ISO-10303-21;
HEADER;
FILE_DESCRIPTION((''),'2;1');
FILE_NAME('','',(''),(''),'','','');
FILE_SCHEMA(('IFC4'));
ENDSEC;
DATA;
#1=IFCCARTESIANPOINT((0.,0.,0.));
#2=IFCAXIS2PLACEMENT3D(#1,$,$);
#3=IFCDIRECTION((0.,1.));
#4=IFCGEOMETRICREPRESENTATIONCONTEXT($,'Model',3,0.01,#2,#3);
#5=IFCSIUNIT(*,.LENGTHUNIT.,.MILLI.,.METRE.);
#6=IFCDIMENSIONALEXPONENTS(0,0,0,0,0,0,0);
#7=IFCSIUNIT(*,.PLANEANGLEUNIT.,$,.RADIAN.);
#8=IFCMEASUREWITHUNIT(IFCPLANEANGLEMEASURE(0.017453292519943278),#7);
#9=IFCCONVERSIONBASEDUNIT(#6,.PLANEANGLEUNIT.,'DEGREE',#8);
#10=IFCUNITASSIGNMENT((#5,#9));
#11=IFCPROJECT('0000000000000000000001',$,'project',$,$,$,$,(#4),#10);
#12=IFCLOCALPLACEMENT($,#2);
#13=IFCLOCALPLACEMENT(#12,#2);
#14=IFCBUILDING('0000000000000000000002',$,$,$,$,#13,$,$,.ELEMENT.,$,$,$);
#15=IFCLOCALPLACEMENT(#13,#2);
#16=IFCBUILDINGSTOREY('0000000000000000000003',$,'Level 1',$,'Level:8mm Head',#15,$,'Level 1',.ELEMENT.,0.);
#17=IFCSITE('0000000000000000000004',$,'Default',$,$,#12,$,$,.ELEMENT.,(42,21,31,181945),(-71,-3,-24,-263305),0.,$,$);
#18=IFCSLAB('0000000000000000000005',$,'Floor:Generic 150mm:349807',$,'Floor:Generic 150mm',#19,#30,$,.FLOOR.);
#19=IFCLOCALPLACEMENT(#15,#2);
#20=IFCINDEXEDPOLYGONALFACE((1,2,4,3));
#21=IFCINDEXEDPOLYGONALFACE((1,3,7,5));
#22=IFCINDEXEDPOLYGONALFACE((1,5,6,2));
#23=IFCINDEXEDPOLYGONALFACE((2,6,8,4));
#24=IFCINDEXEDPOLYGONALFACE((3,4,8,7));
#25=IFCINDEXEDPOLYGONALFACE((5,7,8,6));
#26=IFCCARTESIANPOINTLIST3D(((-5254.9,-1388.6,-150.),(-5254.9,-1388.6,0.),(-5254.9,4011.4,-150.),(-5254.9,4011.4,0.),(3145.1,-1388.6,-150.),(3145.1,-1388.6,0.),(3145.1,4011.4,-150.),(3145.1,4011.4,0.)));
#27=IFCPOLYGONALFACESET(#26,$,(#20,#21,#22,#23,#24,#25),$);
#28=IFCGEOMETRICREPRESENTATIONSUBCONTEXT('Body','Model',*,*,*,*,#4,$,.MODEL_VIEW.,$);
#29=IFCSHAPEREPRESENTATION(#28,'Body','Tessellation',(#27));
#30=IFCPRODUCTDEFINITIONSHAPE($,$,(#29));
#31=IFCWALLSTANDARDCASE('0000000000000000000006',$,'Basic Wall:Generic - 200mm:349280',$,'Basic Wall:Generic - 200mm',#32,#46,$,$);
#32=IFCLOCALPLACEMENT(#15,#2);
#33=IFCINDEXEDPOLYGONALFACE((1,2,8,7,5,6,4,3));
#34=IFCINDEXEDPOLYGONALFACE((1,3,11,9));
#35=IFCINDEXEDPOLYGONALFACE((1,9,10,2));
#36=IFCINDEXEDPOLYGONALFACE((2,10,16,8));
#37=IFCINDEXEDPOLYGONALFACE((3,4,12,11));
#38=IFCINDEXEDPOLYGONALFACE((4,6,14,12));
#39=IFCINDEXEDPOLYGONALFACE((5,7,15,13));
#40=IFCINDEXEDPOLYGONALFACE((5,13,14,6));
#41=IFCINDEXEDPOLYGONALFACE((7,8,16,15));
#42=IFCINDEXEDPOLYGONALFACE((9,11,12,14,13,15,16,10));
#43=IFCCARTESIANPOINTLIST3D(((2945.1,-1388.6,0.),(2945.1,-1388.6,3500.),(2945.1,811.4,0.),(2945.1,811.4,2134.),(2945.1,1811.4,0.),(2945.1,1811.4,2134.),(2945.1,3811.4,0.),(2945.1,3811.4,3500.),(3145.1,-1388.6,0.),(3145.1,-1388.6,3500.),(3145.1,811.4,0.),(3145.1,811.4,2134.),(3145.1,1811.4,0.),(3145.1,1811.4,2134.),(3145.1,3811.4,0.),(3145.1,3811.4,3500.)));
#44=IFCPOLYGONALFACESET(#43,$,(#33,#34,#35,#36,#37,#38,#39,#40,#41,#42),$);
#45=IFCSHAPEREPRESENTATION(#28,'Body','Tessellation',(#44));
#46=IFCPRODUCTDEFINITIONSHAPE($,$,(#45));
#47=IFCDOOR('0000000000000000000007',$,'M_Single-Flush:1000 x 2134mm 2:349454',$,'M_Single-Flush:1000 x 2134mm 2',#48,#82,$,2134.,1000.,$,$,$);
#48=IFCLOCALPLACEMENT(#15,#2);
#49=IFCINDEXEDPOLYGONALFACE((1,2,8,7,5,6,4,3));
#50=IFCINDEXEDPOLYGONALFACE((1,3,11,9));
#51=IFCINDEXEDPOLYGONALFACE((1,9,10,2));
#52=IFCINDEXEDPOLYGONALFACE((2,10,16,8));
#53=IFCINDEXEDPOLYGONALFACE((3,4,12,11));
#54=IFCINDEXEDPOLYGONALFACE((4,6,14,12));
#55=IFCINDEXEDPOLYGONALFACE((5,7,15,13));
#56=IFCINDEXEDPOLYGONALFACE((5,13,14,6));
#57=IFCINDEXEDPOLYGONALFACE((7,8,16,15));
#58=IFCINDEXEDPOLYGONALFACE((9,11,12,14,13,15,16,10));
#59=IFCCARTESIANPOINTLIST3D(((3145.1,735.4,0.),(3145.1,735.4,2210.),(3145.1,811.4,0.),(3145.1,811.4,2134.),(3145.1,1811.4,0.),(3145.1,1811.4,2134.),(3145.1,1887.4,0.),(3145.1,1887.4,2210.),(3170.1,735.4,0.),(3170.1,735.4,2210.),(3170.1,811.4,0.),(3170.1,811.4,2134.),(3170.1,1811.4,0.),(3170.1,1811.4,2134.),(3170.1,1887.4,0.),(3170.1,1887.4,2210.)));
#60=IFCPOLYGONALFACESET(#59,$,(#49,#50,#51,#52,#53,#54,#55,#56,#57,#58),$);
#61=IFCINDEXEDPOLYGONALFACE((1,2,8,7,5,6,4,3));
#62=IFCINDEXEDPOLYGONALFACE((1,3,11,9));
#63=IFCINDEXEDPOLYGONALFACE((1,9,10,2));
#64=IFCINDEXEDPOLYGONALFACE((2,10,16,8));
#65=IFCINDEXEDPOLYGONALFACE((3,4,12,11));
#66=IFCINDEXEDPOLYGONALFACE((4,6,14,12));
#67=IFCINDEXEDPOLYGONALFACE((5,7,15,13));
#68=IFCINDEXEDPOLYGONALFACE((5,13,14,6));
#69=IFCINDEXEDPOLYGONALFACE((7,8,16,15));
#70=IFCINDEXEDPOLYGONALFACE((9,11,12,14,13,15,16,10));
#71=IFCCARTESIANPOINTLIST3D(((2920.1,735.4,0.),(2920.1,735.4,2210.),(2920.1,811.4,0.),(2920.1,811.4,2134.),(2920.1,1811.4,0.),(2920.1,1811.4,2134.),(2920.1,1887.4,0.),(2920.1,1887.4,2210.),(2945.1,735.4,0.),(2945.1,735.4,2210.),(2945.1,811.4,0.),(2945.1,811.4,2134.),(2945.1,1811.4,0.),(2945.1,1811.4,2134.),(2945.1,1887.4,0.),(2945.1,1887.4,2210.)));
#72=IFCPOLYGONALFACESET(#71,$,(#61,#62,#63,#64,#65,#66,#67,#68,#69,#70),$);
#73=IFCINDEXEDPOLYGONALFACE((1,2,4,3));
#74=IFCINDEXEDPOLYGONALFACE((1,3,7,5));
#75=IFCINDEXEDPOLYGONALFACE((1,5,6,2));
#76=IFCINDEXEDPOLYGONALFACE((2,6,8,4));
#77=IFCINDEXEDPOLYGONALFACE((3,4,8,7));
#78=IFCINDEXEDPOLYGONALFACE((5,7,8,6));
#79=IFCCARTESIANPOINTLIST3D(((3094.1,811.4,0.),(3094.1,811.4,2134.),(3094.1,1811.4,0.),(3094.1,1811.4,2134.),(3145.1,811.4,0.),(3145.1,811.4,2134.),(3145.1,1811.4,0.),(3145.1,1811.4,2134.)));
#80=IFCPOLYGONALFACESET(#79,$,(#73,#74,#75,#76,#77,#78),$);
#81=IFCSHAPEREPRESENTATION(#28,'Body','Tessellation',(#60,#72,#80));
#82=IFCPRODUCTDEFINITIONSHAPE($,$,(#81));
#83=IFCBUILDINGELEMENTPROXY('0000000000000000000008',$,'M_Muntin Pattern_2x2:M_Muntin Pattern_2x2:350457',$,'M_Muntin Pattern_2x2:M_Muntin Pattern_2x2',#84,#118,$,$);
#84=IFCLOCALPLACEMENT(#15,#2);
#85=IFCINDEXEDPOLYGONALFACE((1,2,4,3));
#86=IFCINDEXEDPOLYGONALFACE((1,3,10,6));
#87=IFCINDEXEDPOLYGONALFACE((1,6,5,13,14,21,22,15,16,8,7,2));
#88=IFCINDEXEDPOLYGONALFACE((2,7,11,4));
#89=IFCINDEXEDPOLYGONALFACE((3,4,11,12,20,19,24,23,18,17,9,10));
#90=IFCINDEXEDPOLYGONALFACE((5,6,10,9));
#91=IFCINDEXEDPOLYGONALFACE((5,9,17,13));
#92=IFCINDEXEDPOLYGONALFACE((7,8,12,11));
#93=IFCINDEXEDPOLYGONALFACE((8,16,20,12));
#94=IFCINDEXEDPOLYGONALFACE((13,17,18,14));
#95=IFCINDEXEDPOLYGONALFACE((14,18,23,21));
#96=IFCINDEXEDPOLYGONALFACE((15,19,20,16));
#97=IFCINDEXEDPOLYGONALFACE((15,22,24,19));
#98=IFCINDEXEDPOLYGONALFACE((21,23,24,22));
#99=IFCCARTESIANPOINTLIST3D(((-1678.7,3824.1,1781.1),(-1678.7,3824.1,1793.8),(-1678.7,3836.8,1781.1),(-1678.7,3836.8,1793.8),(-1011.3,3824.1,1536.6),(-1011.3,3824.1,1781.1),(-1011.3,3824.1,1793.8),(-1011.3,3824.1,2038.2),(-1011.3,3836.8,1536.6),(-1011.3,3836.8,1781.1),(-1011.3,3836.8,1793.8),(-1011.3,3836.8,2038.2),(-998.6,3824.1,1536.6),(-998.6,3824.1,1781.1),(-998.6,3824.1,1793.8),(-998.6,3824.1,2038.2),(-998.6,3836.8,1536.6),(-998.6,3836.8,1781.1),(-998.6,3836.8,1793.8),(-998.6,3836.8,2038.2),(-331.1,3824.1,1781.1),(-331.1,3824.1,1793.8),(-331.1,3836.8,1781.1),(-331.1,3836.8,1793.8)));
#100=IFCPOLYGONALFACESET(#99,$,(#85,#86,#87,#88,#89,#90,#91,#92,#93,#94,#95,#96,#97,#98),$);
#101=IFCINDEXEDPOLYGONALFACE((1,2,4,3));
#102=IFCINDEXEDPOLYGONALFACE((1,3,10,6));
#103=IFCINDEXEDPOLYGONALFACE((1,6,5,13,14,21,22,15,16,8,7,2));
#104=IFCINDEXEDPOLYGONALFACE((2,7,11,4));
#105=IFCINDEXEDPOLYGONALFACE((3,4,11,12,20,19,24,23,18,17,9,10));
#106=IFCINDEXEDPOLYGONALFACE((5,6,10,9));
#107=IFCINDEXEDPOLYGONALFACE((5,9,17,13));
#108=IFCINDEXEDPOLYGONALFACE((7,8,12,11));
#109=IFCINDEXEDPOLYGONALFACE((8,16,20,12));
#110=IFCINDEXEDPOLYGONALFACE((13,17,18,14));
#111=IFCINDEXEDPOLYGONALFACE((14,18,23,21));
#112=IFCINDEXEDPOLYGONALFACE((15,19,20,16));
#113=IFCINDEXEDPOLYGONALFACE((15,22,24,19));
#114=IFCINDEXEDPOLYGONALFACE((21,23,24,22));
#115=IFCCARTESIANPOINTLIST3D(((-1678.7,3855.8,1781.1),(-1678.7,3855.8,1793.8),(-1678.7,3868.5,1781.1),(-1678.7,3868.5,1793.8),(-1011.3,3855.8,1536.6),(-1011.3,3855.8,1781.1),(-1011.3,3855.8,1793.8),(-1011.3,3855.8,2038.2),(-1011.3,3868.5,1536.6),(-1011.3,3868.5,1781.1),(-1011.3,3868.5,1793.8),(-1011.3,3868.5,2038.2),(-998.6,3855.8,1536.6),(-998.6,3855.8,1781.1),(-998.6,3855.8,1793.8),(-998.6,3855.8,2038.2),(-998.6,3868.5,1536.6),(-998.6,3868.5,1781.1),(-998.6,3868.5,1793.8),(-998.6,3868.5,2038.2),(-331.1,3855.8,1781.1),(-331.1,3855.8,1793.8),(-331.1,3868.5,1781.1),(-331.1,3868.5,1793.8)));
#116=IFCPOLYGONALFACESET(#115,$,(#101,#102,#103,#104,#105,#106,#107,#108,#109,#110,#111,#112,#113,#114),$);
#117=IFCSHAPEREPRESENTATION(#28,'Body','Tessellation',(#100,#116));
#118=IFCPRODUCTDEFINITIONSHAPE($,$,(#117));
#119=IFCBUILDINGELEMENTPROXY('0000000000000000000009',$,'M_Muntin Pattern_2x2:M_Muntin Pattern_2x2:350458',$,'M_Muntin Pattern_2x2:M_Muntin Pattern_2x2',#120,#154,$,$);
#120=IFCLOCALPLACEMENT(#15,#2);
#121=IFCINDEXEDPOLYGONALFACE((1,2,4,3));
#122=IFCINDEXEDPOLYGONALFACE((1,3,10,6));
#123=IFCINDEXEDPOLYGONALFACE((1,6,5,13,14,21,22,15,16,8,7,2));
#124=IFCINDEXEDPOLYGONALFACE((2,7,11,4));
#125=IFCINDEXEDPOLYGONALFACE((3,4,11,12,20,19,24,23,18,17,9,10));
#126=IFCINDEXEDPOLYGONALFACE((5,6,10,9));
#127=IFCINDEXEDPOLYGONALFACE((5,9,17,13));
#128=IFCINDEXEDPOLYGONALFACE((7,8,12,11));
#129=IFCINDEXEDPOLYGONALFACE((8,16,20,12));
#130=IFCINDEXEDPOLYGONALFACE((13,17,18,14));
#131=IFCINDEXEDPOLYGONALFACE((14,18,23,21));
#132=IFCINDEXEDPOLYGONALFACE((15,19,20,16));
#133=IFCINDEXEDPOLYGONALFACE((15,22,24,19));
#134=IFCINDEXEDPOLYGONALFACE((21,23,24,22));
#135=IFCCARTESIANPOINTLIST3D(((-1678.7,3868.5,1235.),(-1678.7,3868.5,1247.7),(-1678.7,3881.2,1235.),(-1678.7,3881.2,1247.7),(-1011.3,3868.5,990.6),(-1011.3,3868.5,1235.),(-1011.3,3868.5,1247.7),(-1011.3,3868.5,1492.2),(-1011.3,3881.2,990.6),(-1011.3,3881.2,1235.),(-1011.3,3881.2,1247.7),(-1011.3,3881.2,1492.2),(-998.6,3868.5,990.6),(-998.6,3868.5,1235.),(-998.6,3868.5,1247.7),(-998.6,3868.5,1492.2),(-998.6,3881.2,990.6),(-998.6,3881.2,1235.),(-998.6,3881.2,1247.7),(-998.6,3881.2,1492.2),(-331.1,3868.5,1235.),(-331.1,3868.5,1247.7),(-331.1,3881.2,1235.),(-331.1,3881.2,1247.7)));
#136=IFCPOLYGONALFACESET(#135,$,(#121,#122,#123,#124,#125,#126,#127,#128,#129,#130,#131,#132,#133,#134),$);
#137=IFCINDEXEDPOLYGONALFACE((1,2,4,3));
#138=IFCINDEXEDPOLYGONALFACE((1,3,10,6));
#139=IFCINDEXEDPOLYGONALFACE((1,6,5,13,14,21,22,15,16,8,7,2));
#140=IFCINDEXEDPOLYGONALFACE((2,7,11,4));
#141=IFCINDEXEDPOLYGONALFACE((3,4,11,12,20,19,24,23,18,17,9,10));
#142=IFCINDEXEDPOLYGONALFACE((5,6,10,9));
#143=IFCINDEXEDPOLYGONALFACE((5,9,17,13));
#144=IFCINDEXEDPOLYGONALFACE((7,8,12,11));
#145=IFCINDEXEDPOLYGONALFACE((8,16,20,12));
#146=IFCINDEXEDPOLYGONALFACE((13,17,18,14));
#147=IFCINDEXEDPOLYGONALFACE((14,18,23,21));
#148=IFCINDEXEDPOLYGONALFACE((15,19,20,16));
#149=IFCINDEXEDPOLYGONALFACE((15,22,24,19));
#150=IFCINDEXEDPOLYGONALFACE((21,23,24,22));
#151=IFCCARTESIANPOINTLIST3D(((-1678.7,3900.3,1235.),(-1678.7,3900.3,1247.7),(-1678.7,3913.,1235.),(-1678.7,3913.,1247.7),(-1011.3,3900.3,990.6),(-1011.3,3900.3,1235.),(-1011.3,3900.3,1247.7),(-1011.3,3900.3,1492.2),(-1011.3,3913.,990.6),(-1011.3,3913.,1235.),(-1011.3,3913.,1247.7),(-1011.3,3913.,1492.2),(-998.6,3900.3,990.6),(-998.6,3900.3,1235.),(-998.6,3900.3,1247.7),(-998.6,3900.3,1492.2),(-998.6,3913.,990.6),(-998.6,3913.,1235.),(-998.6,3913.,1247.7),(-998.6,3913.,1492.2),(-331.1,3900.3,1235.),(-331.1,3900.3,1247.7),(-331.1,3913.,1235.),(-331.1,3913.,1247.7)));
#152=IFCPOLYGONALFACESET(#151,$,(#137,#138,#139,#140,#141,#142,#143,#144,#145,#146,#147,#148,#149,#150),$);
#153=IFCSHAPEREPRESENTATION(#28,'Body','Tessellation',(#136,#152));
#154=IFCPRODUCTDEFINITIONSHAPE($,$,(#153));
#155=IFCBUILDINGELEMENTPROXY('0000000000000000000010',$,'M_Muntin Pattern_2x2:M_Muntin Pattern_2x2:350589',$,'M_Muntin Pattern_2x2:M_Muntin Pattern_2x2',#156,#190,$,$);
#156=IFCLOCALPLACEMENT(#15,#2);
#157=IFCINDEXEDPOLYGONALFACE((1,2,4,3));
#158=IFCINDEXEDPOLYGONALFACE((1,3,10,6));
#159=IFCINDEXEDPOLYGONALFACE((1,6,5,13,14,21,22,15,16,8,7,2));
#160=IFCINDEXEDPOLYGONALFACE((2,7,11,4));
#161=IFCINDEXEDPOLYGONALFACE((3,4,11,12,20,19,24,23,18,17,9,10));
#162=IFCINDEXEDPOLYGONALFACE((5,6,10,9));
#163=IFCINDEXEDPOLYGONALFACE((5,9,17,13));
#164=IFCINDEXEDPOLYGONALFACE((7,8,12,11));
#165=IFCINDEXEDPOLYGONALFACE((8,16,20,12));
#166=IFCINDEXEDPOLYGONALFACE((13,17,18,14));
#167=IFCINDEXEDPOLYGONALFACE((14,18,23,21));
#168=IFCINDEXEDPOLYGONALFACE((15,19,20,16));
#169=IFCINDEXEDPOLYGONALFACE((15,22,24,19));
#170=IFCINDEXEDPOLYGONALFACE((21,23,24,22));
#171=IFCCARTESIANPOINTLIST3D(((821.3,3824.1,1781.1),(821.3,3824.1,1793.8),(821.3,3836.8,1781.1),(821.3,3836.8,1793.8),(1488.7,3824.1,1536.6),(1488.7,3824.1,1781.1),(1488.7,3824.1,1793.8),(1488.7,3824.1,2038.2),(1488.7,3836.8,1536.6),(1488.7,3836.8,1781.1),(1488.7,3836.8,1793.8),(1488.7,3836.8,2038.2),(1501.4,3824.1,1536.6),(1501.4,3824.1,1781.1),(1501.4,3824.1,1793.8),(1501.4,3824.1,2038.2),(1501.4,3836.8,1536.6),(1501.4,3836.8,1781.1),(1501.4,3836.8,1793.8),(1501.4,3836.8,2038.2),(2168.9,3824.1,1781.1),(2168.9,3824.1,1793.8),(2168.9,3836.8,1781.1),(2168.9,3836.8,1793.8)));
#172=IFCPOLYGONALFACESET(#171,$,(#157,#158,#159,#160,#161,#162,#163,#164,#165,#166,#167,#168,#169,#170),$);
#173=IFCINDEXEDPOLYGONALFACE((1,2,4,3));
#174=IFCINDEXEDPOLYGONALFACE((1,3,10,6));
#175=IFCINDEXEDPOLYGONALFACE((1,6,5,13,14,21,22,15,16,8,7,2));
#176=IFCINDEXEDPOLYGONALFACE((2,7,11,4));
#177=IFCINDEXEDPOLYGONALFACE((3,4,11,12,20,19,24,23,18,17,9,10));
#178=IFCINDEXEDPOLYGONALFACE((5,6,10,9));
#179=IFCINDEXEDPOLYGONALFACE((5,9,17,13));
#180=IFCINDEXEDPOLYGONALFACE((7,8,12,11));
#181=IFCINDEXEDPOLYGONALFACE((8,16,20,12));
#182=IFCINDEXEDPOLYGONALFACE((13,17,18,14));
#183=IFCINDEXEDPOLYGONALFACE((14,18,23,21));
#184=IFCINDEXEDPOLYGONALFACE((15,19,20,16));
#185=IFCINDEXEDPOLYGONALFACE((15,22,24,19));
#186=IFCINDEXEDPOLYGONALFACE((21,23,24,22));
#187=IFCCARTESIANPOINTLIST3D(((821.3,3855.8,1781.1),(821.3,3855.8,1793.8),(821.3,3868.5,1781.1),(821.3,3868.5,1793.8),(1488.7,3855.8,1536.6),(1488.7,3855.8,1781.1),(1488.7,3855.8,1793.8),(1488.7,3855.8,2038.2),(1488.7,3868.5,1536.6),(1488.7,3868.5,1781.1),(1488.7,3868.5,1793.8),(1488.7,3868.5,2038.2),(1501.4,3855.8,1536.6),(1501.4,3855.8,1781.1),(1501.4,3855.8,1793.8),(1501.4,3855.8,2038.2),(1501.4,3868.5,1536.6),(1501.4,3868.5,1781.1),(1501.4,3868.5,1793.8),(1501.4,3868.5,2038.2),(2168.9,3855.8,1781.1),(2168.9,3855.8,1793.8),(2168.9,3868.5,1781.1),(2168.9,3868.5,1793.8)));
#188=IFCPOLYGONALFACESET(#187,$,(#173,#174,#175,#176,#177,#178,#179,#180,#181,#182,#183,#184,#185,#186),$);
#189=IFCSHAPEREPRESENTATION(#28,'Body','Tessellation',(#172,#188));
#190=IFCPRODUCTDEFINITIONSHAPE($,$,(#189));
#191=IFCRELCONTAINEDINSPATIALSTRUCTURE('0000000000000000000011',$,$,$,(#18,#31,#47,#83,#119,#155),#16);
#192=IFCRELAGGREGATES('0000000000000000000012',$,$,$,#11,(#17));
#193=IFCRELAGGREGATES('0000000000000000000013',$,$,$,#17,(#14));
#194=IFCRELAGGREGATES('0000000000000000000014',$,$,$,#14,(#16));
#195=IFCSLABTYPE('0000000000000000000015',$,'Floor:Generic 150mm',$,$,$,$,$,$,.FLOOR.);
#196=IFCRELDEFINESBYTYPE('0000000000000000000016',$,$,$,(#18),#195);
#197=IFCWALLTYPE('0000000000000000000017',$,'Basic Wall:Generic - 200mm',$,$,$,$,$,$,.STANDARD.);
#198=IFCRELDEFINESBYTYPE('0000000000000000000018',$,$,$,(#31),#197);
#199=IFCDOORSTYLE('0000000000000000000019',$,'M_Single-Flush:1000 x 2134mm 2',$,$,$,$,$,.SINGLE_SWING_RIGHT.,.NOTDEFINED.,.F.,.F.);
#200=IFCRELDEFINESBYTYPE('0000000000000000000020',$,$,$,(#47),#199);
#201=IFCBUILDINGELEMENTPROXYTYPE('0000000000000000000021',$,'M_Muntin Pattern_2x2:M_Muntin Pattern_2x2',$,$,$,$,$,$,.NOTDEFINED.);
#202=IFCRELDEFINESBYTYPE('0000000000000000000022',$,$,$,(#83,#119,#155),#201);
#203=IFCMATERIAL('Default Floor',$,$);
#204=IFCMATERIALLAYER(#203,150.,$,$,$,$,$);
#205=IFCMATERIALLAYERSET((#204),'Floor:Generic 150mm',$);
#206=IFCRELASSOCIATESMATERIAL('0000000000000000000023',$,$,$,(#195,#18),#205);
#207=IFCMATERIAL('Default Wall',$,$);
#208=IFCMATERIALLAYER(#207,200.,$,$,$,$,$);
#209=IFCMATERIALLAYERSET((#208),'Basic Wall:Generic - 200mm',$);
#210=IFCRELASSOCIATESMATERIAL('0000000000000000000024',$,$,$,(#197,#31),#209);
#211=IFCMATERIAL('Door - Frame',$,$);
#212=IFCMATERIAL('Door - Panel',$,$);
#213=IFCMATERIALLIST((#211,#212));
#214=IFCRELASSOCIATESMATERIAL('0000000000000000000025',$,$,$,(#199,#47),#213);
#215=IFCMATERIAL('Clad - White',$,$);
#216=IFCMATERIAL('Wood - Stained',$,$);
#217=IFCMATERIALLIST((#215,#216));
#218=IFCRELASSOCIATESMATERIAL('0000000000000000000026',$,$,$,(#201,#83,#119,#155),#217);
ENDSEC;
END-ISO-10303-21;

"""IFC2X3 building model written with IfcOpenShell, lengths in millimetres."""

from ifc_helpers import new_model, entity, si_unit, converted_unit, direction, frame, frame_2d, origin, place, context, subcontext, project, spatial, polyline, rectangle, outline, extrude, source, transform, mapped, material, material_list, layer, layer_set, layer_usage, type_object, type_shapes, element, fill, save


model = new_model("IFC2X3")

# Units and contexts
model_context = context("Model", 3, precision=0.01, world=origin(), true_north=direction((0.0, 1.0)))
body_context = subcontext(model_context, "Body", "Model", "MODEL_VIEW")
ifc_project = project(units=[si_unit("LENGTHUNIT", "METRE", prefix="MILLI"), converted_unit("PLANEANGLEUNIT", "DEGREE", entity("IfcPlaneAngleMeasure", 0.017453292519943278), si_unit("PLANEANGLEUNIT", "RADIAN"), dimensions=[0, 0, 0, 0, 0, 0, 0])], contexts=[model_context])

# Site, building, storey
site_placement = place(None, origin())
site = spatial("IfcSite", under=ifc_project, at=site_placement, Name="Default", CompositionType="ELEMENT", RefLatitude=(42, 21, 31, 181945), RefLongitude=(-71, -3, -24, -263305), RefElevation=0.0)
building_placement = place(site_placement, origin())
building = spatial("IfcBuilding", under=site, at=building_placement, CompositionType="ELEMENT")
storey_placement = place(building_placement, origin())
storey = spatial("IfcBuildingStorey", under=building, at=storey_placement, Name="Level 1", ObjectType="Level:8mm Head", LongName="Level 1", CompositionType="ELEMENT", Elevation=0.0)

# Slab
ifc_material_1 = material(Name="Default Floor")
ifc_layer_1 = layer(ifc_material_1, 150.0)
ifc_layer_set_1 = layer_set([ifc_layer_1], Name="Floor:Generic 150mm")
ifc_layer_usage_1 = layer_usage(ifc_layer_set_1, "AXIS3", "POSITIVE", 0.0)
slab_type = type_object("IfcSlabType", Name="Floor:Generic 150mm", PredefinedType="FLOOR", material=ifc_layer_set_1)
slab_placement = place(storey_placement, origin())
element("IfcSlab", 1, at=slab_placement, inside=storey, type_object=slab_type, material=ifc_layer_usage_1, Name="Floor:Generic 150mm:349807", ObjectType="Floor:Generic 150mm", PredefinedType="FLOOR", context=body_context, shape_type="SweptSolid", body=[
    extrude(rectangle(XDim=5400.0, YDim=8400.0, at=frame_2d((0.0, 0.0), x_axis=(1.0, 0.0))), frame((-1054.9, 1311.4, 0.0), z_axis=(0.0, 0.0, -1.0), x_axis=(0.0, 1.0, 0.0)), (0.0, 0.0, 1.0), 150.0),
])

# Wall, opening, door
ifc_material_2 = material(Name="Default Wall")
ifc_layer_2 = layer(ifc_material_2, 200.0)
ifc_layer_set_2 = layer_set([ifc_layer_2], Name="Basic Wall:Generic - 200mm")
ifc_layer_usage_2 = layer_usage(ifc_layer_set_2, "AXIS2", "NEGATIVE", 100.0)
wall_type = type_object("IfcWallType", Name="Basic Wall:Generic - 200mm", PredefinedType="STANDARD", material=ifc_layer_set_2)
wall_1_placement = place(storey_placement, frame((3045.1, 3811.4, 0.0), z_axis=(0.0, 0.0, 1.0), x_axis=(0.0, -1.0, 0.0)))
wall_1 = element("IfcWallStandardCase", 2, at=wall_1_placement, inside=storey, type_object=wall_type, material=ifc_layer_usage_2, Name="Basic Wall:Generic - 200mm:349280", ObjectType="Basic Wall:Generic - 200mm", context=body_context, shape_type="SweptSolid", body=[
    extrude(rectangle(XDim=5200.0, YDim=200.0, at=frame_2d((2600.0, 0.0), x_axis=(-1.0, 0.0))), origin(), (0.0, 0.0, 1.0), 3500.0),
])
opening_1_placement = place(wall_1_placement, frame((2000.0, -100.0, 0.0)))
opening_1 = element("IfcOpeningElement", 3, at=opening_1_placement, cuts=wall_1, ObjectType="Opening", context=body_context, shape_type="SweptSolid", body=[
    extrude(rectangle(XDim=1000.0, YDim=2134.0, at=frame_2d((1067.0, 500.0), x_axis=(0.0, 1.0))), frame((0.0, 0.0, 0.0), z_axis=(0.0, 1.0, 0.0), x_axis=(0.0, 0.0, 1.0)), (0.0, 0.0, 1.0), 200.0),
])
ifc_material_3 = material(Name="Door - Frame")
ifc_material_4 = material(Name="Door - Panel")
ifc_material_list_1 = material_list([ifc_material_3, ifc_material_4])
door_style = type_object("IfcDoorStyle", Name="M_Single-Flush:1000 x 2134mm 2", ConstructionType="NOTDEFINED", OperationType="SINGLE_SWING_RIGHT", ParameterTakesPrecedence=False, Sizeable=False, material=ifc_material_list_1)
shared_shape_1 = source(origin(), body_context, "Body", "SweptSolid", [
    extrude(outline(polyline([(-576.0, -1124.0), (576.0, -1124.0), (576.0, 1086.0), (500.0, 1086.0), (500.0, -1048.0), (-500.0, -1048.0), (-500.0, 1086.0), (-576.0, 1086.0), (-576.0, -1124.0)])), frame((500.0, 200.0, 1086.0), z_axis=(0.0, 1.0, 0.0), x_axis=(1.0, 0.0, 0.0)), (0.0, 0.0, 1.0), 25.0),
    extrude(outline(polyline([(-1124.0, -576.0), (1086.0, -576.0), (1086.0, -500.0), (-1048.0, -500.0), (-1048.0, 500.0), (1086.0, 500.0), (1086.0, 576.0), (-1124.0, 576.0), (-1124.0, -576.0)])), frame((500.0, -25.0, 1086.0), z_axis=(0.0, 1.0, 0.0), x_axis=(0.0, 0.0, -1.0)), (0.0, 0.0, 1.0), 25.0),
    extrude(rectangle(XDim=51.0, YDim=1000.0, at=frame_2d((0.0, 0.0), x_axis=(1.0, 0.0))), frame((500.0, 174.5, 0.0), z_axis=(0.0, 0.0, 1.0), x_axis=(0.0, 1.0, 0.0)), (0.0, 0.0, 1.0), 2134.0),
])
type_shapes(door_style, [shared_shape_1])
door_placement = place(opening_1_placement, origin())
door = element("IfcDoor", 4, at=door_placement, inside=storey, type_object=door_style, material=ifc_material_list_1, Name="M_Single-Flush:1000 x 2134mm 2:349454", ObjectType="M_Single-Flush:1000 x 2134mm 2", OverallHeight=2134.0, OverallWidth=1000.0, context=body_context, shape_type="MappedRepresentation", body=[
    mapped(shared_shape_1, transform((0.0, 0.0, 0.0), scale=1.0)),
])
fill(opening_1, door)

# Shared definitions
ifc_material_5 = material(Name="Wood - Stained")

# Building element proxies
ifc_material_6 = material(Name="Clad - White")
ifc_material_list_2 = material_list([ifc_material_6, ifc_material_5])
building_element_proxy_type_1 = type_object("IfcBuildingElementProxyType", Name="M_Muntin Pattern_2x2:M_Muntin Pattern_2x2", PredefinedType="NOTDEFINED", material=ifc_material_list_2)
shared_shape_2 = source(origin(), body_context, "Body", "SweptSolid", [
    extrude(outline(polyline([(6.4, -6.4), (250.8, -6.4), (250.8, 6.3), (6.4, 6.3), (6.4, 673.8), (-6.3, 673.8), (-6.3, 6.3), (-250.8, 6.3), (-250.8, -6.4), (-6.3, -6.4), (-6.3, -673.8), (6.4, -673.8), (6.4, -6.4)])), frame((0.0, 9.5, 250.8), z_axis=(0.0, 1.0, 0.0), x_axis=(0.0, 0.0, 1.0)), (0.0, 0.0, 1.0), 12.7),
    extrude(outline(polyline([(6.4, -6.4), (250.8, -6.4), (250.8, 6.3), (6.4, 6.3), (6.4, 673.8), (-6.3, 673.8), (-6.3, 6.3), (-250.8, 6.3), (-250.8, -6.4), (-6.3, -6.4), (-6.3, -673.8), (6.4, -673.8), (6.4, -6.4)])), frame((0.0, -22.2, 250.8), z_axis=(0.0, 1.0, 0.0), x_axis=(0.0, 0.0, 1.0)), (0.0, 0.0, 1.0), 12.7),
])
type_shapes(building_element_proxy_type_1, [shared_shape_2])
for number, where, z_axis, x_axis, name in (
    (5, (-1004.9, 3846.3, 1536.6), (0.0, 0.0, 1.0), (-1.0, 0.0, 0.0), "M_Muntin Pattern_2x2:M_Muntin Pattern_2x2:350457"),
    (6, (-1004.9, 3890.7, 990.6), (0.0, 0.0, 1.0), (-1.0, 0.0, 0.0), "M_Muntin Pattern_2x2:M_Muntin Pattern_2x2:350458"),
    (7, (1495.1, 3846.3, 1536.6), (0.0, 0.0, 1.0), (-1.0, 0.0, 0.0), "M_Muntin Pattern_2x2:M_Muntin Pattern_2x2:350589"),
):
    element("IfcBuildingElementProxy", number, at=place(storey_placement, frame(where, z_axis=z_axis, x_axis=x_axis)), inside=storey, type_object=building_element_proxy_type_1, material=ifc_material_list_2, Name=name, ObjectType="M_Muntin Pattern_2x2:M_Muntin Pattern_2x2", context=body_context, shape_type="MappedRepresentation", body=[
        mapped(shared_shape_2, transform((0.0, 0.0, 0.0), scale=1.0)),
    ])

save(model, "model.ifc")
